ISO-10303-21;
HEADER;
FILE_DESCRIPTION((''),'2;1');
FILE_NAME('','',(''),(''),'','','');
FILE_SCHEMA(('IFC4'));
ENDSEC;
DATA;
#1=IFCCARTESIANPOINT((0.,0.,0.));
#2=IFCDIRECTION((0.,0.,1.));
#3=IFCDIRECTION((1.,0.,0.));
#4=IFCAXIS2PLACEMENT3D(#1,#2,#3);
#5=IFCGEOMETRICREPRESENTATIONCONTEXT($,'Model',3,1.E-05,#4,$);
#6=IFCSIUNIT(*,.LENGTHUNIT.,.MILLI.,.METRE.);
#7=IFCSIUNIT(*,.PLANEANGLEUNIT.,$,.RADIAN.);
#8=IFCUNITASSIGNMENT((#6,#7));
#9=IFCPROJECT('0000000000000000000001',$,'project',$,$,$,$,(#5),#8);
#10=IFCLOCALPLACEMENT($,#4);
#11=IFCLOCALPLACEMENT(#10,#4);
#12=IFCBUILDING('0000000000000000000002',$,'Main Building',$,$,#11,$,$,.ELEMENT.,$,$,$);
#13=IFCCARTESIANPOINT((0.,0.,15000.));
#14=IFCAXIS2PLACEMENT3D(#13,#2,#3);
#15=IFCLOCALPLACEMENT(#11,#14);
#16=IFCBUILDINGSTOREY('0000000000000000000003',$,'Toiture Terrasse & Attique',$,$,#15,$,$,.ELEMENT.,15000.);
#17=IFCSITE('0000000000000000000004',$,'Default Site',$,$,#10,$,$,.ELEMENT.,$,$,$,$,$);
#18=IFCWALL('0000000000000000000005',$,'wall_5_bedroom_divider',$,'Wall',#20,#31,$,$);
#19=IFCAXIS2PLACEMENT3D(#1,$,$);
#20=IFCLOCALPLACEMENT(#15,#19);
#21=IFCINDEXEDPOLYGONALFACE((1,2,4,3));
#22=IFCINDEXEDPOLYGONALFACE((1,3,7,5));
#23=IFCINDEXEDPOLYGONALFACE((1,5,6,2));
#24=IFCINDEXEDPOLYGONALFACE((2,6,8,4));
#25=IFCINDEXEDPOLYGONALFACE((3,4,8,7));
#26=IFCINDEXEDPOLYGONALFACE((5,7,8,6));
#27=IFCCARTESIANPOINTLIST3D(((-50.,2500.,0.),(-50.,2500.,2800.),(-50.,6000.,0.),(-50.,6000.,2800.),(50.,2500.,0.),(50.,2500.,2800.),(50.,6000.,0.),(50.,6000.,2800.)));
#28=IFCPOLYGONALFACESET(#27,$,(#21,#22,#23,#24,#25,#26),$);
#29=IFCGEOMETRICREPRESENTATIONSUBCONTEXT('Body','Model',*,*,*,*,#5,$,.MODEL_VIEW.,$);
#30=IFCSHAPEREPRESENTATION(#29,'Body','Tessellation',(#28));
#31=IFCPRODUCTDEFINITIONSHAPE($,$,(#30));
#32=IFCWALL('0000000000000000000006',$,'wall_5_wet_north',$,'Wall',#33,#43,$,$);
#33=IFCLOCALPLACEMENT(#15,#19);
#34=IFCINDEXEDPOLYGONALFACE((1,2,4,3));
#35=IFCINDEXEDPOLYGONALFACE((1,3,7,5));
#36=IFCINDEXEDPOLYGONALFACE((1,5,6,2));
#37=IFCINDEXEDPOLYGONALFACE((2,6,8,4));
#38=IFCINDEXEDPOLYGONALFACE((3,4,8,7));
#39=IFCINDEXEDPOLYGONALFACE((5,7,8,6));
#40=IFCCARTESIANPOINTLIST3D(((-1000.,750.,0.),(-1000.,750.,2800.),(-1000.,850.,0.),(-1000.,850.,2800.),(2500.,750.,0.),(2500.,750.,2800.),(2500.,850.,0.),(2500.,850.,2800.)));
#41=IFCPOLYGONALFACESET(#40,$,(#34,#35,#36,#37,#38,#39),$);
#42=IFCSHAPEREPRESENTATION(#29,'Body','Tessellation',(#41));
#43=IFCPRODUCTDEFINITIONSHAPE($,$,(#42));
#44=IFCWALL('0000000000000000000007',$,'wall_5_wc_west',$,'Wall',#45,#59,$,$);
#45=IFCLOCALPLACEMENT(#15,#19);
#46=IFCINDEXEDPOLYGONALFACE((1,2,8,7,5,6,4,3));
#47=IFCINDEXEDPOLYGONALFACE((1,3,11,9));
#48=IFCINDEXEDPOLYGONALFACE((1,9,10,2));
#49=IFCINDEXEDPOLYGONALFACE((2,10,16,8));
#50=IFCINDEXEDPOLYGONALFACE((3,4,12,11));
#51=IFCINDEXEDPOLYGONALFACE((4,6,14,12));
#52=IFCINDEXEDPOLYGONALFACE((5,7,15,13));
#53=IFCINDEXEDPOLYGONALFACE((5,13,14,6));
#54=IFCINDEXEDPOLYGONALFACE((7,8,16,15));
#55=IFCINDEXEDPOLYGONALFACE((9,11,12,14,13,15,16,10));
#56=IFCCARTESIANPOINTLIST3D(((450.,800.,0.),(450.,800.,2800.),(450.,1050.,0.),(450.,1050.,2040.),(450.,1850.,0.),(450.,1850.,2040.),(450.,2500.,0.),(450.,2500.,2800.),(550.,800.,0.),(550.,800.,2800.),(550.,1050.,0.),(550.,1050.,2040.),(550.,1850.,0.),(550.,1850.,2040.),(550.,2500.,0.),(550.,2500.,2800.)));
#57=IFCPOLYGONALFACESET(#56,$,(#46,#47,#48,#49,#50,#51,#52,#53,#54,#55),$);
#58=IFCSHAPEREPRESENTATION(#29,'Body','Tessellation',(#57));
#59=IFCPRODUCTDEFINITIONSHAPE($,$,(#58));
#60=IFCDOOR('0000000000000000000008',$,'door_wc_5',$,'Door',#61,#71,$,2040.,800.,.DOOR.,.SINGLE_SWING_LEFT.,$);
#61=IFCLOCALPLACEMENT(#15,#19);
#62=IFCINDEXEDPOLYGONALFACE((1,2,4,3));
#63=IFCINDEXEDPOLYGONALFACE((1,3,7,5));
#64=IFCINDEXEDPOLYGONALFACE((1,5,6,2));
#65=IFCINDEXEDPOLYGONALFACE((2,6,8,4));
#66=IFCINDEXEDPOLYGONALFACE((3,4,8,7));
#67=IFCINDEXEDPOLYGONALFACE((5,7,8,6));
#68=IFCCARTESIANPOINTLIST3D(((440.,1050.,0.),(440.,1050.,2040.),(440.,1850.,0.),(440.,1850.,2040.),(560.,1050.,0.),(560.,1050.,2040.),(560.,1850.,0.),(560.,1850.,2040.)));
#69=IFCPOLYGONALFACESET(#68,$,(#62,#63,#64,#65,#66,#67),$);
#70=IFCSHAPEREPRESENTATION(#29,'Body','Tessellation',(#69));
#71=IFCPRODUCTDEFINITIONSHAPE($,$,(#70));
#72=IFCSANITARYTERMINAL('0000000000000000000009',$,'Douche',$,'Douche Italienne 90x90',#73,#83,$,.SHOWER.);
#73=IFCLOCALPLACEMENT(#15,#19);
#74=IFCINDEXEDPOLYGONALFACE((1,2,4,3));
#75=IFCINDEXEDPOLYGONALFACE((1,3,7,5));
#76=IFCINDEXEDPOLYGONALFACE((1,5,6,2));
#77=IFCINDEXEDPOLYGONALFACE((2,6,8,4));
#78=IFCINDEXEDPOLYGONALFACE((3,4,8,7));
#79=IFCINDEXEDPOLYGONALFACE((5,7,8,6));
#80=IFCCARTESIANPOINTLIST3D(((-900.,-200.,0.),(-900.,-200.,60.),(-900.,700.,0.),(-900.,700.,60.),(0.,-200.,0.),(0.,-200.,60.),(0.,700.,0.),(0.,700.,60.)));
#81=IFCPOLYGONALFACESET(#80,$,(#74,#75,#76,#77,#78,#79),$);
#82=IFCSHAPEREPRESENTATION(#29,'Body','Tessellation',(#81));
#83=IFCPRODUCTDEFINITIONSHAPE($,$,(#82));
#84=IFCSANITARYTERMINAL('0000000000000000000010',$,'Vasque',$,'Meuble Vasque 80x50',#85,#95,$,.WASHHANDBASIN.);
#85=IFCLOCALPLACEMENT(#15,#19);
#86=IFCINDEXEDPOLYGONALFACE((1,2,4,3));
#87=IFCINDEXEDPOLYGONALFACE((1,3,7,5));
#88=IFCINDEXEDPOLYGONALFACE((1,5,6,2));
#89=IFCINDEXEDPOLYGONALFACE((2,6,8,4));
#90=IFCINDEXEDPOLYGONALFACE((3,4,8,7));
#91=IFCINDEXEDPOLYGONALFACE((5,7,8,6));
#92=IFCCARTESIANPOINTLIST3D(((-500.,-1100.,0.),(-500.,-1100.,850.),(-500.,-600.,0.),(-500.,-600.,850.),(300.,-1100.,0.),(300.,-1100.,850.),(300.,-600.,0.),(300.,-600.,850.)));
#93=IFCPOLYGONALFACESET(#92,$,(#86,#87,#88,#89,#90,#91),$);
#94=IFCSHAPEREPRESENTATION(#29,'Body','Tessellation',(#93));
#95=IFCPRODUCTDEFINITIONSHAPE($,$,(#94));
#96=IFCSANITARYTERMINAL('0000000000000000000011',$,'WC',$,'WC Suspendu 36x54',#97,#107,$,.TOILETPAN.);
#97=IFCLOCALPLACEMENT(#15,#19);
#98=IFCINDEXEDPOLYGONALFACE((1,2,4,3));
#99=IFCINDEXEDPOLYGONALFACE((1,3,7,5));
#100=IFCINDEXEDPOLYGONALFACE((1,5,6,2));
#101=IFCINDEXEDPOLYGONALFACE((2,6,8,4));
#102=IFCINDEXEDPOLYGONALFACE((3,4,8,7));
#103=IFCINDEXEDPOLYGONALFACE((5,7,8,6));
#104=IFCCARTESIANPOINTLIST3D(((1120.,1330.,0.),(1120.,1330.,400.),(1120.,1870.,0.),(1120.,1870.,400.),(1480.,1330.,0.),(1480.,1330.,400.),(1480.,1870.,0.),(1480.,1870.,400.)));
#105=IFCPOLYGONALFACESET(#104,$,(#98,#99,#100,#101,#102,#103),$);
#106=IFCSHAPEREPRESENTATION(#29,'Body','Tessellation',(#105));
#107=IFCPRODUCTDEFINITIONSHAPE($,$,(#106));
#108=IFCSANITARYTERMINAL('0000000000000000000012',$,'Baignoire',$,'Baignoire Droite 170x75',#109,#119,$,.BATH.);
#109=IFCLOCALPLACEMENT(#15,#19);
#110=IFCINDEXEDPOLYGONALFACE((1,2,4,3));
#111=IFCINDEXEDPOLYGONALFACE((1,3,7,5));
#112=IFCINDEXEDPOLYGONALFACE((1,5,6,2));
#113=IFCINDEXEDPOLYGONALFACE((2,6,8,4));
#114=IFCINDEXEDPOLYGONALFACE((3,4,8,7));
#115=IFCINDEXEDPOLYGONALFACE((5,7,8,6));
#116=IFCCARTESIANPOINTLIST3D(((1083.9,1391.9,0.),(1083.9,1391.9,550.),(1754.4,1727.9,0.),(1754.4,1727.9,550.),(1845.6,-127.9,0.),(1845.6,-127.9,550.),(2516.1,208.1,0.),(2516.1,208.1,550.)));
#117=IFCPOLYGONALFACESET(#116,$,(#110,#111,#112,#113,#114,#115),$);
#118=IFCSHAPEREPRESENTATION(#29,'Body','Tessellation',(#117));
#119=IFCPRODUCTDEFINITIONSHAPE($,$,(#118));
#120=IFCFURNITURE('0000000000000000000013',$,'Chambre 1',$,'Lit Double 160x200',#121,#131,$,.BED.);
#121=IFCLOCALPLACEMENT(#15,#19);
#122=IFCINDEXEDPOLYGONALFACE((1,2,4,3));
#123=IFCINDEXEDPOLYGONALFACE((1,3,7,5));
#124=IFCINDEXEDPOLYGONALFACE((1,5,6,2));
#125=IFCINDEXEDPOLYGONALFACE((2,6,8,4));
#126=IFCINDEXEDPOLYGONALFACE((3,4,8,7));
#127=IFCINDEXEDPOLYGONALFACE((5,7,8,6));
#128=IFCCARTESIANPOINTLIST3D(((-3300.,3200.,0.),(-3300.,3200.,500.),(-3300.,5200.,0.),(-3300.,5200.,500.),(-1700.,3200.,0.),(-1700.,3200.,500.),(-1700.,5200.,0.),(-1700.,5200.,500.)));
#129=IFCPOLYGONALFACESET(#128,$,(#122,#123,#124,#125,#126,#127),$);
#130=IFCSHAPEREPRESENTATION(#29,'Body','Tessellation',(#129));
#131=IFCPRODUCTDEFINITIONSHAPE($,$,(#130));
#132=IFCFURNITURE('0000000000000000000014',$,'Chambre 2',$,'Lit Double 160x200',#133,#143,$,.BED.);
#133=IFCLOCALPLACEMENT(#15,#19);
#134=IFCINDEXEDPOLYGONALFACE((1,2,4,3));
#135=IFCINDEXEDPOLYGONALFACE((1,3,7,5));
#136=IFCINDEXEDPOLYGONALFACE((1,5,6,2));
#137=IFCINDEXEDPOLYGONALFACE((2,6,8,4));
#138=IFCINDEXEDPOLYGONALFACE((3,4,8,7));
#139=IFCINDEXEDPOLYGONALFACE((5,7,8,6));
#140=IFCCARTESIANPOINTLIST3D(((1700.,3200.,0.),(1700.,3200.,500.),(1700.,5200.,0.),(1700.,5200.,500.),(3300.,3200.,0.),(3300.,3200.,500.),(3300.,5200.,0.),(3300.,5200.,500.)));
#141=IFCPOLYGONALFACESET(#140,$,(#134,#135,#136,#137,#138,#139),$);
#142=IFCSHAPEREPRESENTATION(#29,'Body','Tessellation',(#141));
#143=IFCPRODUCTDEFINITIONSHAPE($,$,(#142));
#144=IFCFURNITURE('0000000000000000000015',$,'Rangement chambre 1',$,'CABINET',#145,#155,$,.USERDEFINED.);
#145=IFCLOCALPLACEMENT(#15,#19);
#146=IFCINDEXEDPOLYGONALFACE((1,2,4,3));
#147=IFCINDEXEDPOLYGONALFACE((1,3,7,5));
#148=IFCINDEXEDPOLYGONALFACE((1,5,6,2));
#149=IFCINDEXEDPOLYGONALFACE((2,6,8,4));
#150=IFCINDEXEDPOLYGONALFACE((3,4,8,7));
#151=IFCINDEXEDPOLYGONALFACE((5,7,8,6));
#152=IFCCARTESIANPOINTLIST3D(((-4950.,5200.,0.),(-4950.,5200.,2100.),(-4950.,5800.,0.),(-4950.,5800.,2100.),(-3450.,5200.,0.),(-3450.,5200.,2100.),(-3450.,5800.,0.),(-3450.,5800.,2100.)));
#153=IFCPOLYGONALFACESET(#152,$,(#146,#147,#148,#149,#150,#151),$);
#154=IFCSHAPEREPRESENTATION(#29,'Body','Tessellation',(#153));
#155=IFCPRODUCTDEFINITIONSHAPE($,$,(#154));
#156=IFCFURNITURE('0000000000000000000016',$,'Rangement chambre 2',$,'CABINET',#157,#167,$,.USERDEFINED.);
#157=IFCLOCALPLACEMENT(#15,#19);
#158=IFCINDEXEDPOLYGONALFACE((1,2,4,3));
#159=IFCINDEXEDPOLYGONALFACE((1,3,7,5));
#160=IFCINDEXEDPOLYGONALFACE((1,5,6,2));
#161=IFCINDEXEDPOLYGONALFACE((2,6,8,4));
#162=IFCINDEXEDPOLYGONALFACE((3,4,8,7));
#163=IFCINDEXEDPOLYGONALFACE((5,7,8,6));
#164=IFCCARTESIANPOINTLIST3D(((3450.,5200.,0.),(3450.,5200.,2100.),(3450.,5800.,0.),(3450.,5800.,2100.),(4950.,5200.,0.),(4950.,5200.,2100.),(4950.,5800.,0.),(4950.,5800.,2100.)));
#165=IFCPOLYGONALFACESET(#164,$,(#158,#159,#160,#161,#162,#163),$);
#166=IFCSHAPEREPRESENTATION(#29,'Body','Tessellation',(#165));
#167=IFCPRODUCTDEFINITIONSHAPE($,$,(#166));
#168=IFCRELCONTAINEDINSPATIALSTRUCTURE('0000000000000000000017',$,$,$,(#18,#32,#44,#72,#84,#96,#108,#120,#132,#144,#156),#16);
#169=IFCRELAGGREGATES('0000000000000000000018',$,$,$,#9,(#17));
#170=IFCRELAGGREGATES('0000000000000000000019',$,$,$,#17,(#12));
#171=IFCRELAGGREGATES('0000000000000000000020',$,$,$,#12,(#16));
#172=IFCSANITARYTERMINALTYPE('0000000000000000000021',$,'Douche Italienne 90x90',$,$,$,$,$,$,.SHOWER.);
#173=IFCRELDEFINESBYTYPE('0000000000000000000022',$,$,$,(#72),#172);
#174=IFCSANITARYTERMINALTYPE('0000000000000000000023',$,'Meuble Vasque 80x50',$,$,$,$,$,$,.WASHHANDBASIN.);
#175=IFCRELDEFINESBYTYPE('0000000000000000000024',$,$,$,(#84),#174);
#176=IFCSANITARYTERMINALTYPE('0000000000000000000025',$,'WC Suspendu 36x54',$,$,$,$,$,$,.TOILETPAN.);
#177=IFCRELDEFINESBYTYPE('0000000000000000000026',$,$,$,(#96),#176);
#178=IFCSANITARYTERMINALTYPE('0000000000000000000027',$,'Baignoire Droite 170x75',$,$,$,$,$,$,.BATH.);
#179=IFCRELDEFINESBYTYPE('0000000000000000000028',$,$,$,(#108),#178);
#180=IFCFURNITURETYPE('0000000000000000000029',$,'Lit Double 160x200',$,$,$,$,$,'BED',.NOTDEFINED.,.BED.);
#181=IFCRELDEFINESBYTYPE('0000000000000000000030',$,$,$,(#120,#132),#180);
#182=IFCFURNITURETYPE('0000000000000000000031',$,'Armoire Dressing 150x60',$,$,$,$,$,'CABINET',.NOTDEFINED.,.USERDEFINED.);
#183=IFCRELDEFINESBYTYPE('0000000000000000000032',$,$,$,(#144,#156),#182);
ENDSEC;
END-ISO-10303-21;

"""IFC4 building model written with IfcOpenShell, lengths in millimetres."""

from ifc_helpers import new_model, si_unit, frame, origin_with_axes, place, context, subcontext, project, spatial, polyline, outline, extrude, type_object, element, fill, save


model = new_model("IFC4")

# Units and contexts
model_context = context("Model", 3, precision=1e-05, world=origin_with_axes())
body_context = subcontext(model_context, "Body", "Model", "MODEL_VIEW")
ifc_project = project(units=[si_unit("LENGTHUNIT", "METRE", prefix="MILLI"), si_unit("PLANEANGLEUNIT", "RADIAN")], contexts=[model_context])

# Site, building, storey
site_placement = place(None, origin_with_axes())
site = spatial("IfcSite", under=ifc_project, at=site_placement, Name="Default Site", CompositionType="ELEMENT")
building_placement = place(site_placement, origin_with_axes())
building = spatial("IfcBuilding", under=site, at=building_placement, Name="Main Building", CompositionType="ELEMENT")
storey_placement = place(building_placement, frame((0.0, 0.0, 15000.0), z_axis=(0.0, 0.0, 1.0), x_axis=(1.0, 0.0, 0.0)))
storey = spatial("IfcBuildingStorey", under=building, at=storey_placement, Name="Toiture Terrasse & Attique", CompositionType="ELEMENT", Elevation=15000.0)

# Walls
for number, where, z_axis, x_axis, name in (
    (1, (0.0, 2500.0, 0.0), (0.0, 0.0, 1.0), (0.0, 1.0, 0.0), "wall_5_bedroom_divider"),
    (2, (-1000.0, 800.0, 0.0), (0.0, 0.0, 1.0), (1.0, 0.0, 0.0), "wall_5_wet_north"),
):
    element("IfcWall", number, at=place(storey_placement, frame(where, z_axis=z_axis, x_axis=x_axis)), inside=storey, Name=name, ObjectType="Wall", context=body_context, shape_type="SweptSolid", body=[
        extrude(outline(polyline([(0.0, -50.0), (3500.0, -50.0), (3500.0, 50.0), (0.0, 50.0), (0.0, -50.0)])), origin_with_axes(), (0.0, 0.0, 1.0), 2800.0),
    ])

# Wall, opening, door
wall_1_placement = place(storey_placement, frame((500.0, 800.0, 0.0), z_axis=(0.0, 0.0, 1.0), x_axis=(0.0, 1.0, 0.0)))
wall_1 = element("IfcWall", 3, at=wall_1_placement, inside=storey, Name="wall_5_wc_west", ObjectType="Wall", context=body_context, shape_type="SweptSolid", body=[
    extrude(outline(polyline([(0.0, -50.0), (1700.0, -50.0), (1700.0, 50.0), (0.0, 50.0), (0.0, -50.0)])), origin_with_axes(), (0.0, 0.0, 1.0), 2800.0),
])
placement_1 = place(wall_1_placement, frame((250.0, 0.0, 0.0), z_axis=(0.0, 0.0, 1.0), x_axis=(1.0, 0.0, 0.0)))
opening_1 = element("IfcOpeningElement", 4, at=placement_1, cuts=wall_1, PredefinedType="OPENING", context=body_context, shape_type="SweptSolid", body=[
    extrude(outline(polyline([(0.0, -60.0), (800.0, -60.0), (800.0, 60.0), (0.0, 60.0), (0.0, -60.0)])), origin_with_axes(), (0.0, 0.0, 1.0), 2040.0),
])
door_1 = element("IfcDoor", 5, at=placement_1, Name="door_wc_5", ObjectType="Door", OperationType="SINGLE_SWING_LEFT", OverallHeight=2040.0, OverallWidth=800.0, PredefinedType="DOOR", context=body_context, shape_type="SweptSolid", body=[
    extrude(outline(polyline([(0.0, -60.0), (800.0, -60.0), (800.0, 60.0), (0.0, 60.0), (0.0, -60.0)])), origin_with_axes(), (0.0, 0.0, 1.0), 2040.0),
])
fill(opening_1, door_1)

# Sanitary terminals
sanitary_terminal_type_1 = type_object("IfcSanitaryTerminalType", Name="Douche Italienne 90x90", PredefinedType="SHOWER")
sanitary_terminal_1_placement = place(storey_placement, frame((-450.0, 250.0, 0.0), z_axis=(0.0, 0.0, 1.0), x_axis=(1.0, 0.0, 0.0)))
element("IfcSanitaryTerminal", 6, at=sanitary_terminal_1_placement, inside=storey, type_object=sanitary_terminal_type_1, Name="Douche", ObjectType="Douche Italienne 90x90", PredefinedType="SHOWER", context=body_context, shape_type="SweptSolid", body=[
    extrude(outline(polyline([(-450.0, -450.0), (450.0, -450.0), (450.0, 450.0), (-450.0, 450.0), (-450.0, -450.0)])), origin_with_axes(), (0.0, 0.0, 1.0), 60.0),
])
sanitary_terminal_type_2 = type_object("IfcSanitaryTerminalType", Name="Meuble Vasque 80x50", PredefinedType="WASHHANDBASIN")
sanitary_terminal_2_placement = place(storey_placement, frame((-100.0, -850.0, 0.0), z_axis=(0.0, 0.0, 1.0), x_axis=(1.0, 0.0, 0.0)))
element("IfcSanitaryTerminal", 7, at=sanitary_terminal_2_placement, inside=storey, type_object=sanitary_terminal_type_2, Name="Vasque", ObjectType="Meuble Vasque 80x50", PredefinedType="WASHHANDBASIN", context=body_context, shape_type="SweptSolid", body=[
    extrude(outline(polyline([(-400.0, -250.0), (400.0, -250.0), (400.0, 250.0), (-400.0, 250.0), (-400.0, -250.0)])), origin_with_axes(), (0.0, 0.0, 1.0), 850.0),
])
sanitary_terminal_type_3 = type_object("IfcSanitaryTerminalType", Name="WC Suspendu 36x54", PredefinedType="TOILETPAN")
sanitary_terminal_3_placement = place(storey_placement, frame((1300.0, 1600.0, 0.0), z_axis=(0.0, 0.0, 1.0), x_axis=(1.0, 0.0, 0.0)))
element("IfcSanitaryTerminal", 8, at=sanitary_terminal_3_placement, inside=storey, type_object=sanitary_terminal_type_3, Name="WC", ObjectType="WC Suspendu 36x54", PredefinedType="TOILETPAN", context=body_context, shape_type="SweptSolid", body=[
    extrude(outline(polyline([(-180.0, -270.0), (180.0, -270.0), (180.0, 270.0), (-180.0, 270.0), (-180.0, -270.0)])), origin_with_axes(), (0.0, 0.0, 1.0), 400.0),
])
sanitary_terminal_type_4 = type_object("IfcSanitaryTerminalType", Name="Baignoire Droite 170x75", PredefinedType="BATH")
sanitary_terminal_4_placement = place(storey_placement, frame((1800.0, 800.0, 0.0), z_axis=(0.0, 0.0, 1.0), x_axis=(-0.448074, 0.893997, 0.0)))
element("IfcSanitaryTerminal", 9, at=sanitary_terminal_4_placement, inside=storey, type_object=sanitary_terminal_type_4, Name="Baignoire", ObjectType="Baignoire Droite 170x75", PredefinedType="BATH", context=body_context, shape_type="SweptSolid", body=[
    extrude(outline(polyline([(-850.0, -375.0), (850.0, -375.0), (850.0, 375.0), (-850.0, 375.0), (-850.0, -375.0)])), origin_with_axes(), (0.0, 0.0, 1.0), 550.0),
])

# Furniture
furniture_type_1 = type_object("IfcFurnitureType", Name="Lit Double 160x200", ElementType="BED", AssemblyPlace="NOTDEFINED", PredefinedType="BED")
for number, where, z_axis, x_axis, name in (
    (10, (-2500.0, 4200.0, 0.0), (0.0, 0.0, 1.0), (1.0, 0.0, 0.0), "Chambre 1"),
    (11, (2500.0, 4200.0, 0.0), (0.0, 0.0, 1.0), (1.0, 0.0, 0.0), "Chambre 2"),
):
    element("IfcFurniture", number, at=place(storey_placement, frame(where, z_axis=z_axis, x_axis=x_axis)), inside=storey, type_object=furniture_type_1, Name=name, ObjectType="Lit Double 160x200", PredefinedType="BED", context=body_context, shape_type="SweptSolid", body=[
        extrude(outline(polyline([(-800.0, -1000.0), (800.0, -1000.0), (800.0, 1000.0), (-800.0, 1000.0), (-800.0, -1000.0)])), origin_with_axes(), (0.0, 0.0, 1.0), 500.0),
    ])
furniture_type_2 = type_object("IfcFurnitureType", Name="Armoire Dressing 150x60", ElementType="CABINET", AssemblyPlace="NOTDEFINED", PredefinedType="USERDEFINED")
for number, where, z_axis, x_axis, name in (
    (12, (-4200.0, 5500.0, 0.0), (0.0, 0.0, 1.0), (1.0, 0.0, 0.0), "Rangement chambre 1"),
    (13, (4200.0, 5500.0, 0.0), (0.0, 0.0, 1.0), (1.0, 0.0, 0.0), "Rangement chambre 2"),
):
    element("IfcFurniture", number, at=place(storey_placement, frame(where, z_axis=z_axis, x_axis=x_axis)), inside=storey, type_object=furniture_type_2, Name=name, ObjectType="CABINET", PredefinedType="USERDEFINED", context=body_context, shape_type="SweptSolid", body=[
        extrude(outline(polyline([(-750.0, -300.0), (750.0, -300.0), (750.0, 300.0), (-750.0, 300.0), (-750.0, -300.0)])), origin_with_axes(), (0.0, 0.0, 1.0), 2100.0),
    ])

save(model, "model.ifc")
